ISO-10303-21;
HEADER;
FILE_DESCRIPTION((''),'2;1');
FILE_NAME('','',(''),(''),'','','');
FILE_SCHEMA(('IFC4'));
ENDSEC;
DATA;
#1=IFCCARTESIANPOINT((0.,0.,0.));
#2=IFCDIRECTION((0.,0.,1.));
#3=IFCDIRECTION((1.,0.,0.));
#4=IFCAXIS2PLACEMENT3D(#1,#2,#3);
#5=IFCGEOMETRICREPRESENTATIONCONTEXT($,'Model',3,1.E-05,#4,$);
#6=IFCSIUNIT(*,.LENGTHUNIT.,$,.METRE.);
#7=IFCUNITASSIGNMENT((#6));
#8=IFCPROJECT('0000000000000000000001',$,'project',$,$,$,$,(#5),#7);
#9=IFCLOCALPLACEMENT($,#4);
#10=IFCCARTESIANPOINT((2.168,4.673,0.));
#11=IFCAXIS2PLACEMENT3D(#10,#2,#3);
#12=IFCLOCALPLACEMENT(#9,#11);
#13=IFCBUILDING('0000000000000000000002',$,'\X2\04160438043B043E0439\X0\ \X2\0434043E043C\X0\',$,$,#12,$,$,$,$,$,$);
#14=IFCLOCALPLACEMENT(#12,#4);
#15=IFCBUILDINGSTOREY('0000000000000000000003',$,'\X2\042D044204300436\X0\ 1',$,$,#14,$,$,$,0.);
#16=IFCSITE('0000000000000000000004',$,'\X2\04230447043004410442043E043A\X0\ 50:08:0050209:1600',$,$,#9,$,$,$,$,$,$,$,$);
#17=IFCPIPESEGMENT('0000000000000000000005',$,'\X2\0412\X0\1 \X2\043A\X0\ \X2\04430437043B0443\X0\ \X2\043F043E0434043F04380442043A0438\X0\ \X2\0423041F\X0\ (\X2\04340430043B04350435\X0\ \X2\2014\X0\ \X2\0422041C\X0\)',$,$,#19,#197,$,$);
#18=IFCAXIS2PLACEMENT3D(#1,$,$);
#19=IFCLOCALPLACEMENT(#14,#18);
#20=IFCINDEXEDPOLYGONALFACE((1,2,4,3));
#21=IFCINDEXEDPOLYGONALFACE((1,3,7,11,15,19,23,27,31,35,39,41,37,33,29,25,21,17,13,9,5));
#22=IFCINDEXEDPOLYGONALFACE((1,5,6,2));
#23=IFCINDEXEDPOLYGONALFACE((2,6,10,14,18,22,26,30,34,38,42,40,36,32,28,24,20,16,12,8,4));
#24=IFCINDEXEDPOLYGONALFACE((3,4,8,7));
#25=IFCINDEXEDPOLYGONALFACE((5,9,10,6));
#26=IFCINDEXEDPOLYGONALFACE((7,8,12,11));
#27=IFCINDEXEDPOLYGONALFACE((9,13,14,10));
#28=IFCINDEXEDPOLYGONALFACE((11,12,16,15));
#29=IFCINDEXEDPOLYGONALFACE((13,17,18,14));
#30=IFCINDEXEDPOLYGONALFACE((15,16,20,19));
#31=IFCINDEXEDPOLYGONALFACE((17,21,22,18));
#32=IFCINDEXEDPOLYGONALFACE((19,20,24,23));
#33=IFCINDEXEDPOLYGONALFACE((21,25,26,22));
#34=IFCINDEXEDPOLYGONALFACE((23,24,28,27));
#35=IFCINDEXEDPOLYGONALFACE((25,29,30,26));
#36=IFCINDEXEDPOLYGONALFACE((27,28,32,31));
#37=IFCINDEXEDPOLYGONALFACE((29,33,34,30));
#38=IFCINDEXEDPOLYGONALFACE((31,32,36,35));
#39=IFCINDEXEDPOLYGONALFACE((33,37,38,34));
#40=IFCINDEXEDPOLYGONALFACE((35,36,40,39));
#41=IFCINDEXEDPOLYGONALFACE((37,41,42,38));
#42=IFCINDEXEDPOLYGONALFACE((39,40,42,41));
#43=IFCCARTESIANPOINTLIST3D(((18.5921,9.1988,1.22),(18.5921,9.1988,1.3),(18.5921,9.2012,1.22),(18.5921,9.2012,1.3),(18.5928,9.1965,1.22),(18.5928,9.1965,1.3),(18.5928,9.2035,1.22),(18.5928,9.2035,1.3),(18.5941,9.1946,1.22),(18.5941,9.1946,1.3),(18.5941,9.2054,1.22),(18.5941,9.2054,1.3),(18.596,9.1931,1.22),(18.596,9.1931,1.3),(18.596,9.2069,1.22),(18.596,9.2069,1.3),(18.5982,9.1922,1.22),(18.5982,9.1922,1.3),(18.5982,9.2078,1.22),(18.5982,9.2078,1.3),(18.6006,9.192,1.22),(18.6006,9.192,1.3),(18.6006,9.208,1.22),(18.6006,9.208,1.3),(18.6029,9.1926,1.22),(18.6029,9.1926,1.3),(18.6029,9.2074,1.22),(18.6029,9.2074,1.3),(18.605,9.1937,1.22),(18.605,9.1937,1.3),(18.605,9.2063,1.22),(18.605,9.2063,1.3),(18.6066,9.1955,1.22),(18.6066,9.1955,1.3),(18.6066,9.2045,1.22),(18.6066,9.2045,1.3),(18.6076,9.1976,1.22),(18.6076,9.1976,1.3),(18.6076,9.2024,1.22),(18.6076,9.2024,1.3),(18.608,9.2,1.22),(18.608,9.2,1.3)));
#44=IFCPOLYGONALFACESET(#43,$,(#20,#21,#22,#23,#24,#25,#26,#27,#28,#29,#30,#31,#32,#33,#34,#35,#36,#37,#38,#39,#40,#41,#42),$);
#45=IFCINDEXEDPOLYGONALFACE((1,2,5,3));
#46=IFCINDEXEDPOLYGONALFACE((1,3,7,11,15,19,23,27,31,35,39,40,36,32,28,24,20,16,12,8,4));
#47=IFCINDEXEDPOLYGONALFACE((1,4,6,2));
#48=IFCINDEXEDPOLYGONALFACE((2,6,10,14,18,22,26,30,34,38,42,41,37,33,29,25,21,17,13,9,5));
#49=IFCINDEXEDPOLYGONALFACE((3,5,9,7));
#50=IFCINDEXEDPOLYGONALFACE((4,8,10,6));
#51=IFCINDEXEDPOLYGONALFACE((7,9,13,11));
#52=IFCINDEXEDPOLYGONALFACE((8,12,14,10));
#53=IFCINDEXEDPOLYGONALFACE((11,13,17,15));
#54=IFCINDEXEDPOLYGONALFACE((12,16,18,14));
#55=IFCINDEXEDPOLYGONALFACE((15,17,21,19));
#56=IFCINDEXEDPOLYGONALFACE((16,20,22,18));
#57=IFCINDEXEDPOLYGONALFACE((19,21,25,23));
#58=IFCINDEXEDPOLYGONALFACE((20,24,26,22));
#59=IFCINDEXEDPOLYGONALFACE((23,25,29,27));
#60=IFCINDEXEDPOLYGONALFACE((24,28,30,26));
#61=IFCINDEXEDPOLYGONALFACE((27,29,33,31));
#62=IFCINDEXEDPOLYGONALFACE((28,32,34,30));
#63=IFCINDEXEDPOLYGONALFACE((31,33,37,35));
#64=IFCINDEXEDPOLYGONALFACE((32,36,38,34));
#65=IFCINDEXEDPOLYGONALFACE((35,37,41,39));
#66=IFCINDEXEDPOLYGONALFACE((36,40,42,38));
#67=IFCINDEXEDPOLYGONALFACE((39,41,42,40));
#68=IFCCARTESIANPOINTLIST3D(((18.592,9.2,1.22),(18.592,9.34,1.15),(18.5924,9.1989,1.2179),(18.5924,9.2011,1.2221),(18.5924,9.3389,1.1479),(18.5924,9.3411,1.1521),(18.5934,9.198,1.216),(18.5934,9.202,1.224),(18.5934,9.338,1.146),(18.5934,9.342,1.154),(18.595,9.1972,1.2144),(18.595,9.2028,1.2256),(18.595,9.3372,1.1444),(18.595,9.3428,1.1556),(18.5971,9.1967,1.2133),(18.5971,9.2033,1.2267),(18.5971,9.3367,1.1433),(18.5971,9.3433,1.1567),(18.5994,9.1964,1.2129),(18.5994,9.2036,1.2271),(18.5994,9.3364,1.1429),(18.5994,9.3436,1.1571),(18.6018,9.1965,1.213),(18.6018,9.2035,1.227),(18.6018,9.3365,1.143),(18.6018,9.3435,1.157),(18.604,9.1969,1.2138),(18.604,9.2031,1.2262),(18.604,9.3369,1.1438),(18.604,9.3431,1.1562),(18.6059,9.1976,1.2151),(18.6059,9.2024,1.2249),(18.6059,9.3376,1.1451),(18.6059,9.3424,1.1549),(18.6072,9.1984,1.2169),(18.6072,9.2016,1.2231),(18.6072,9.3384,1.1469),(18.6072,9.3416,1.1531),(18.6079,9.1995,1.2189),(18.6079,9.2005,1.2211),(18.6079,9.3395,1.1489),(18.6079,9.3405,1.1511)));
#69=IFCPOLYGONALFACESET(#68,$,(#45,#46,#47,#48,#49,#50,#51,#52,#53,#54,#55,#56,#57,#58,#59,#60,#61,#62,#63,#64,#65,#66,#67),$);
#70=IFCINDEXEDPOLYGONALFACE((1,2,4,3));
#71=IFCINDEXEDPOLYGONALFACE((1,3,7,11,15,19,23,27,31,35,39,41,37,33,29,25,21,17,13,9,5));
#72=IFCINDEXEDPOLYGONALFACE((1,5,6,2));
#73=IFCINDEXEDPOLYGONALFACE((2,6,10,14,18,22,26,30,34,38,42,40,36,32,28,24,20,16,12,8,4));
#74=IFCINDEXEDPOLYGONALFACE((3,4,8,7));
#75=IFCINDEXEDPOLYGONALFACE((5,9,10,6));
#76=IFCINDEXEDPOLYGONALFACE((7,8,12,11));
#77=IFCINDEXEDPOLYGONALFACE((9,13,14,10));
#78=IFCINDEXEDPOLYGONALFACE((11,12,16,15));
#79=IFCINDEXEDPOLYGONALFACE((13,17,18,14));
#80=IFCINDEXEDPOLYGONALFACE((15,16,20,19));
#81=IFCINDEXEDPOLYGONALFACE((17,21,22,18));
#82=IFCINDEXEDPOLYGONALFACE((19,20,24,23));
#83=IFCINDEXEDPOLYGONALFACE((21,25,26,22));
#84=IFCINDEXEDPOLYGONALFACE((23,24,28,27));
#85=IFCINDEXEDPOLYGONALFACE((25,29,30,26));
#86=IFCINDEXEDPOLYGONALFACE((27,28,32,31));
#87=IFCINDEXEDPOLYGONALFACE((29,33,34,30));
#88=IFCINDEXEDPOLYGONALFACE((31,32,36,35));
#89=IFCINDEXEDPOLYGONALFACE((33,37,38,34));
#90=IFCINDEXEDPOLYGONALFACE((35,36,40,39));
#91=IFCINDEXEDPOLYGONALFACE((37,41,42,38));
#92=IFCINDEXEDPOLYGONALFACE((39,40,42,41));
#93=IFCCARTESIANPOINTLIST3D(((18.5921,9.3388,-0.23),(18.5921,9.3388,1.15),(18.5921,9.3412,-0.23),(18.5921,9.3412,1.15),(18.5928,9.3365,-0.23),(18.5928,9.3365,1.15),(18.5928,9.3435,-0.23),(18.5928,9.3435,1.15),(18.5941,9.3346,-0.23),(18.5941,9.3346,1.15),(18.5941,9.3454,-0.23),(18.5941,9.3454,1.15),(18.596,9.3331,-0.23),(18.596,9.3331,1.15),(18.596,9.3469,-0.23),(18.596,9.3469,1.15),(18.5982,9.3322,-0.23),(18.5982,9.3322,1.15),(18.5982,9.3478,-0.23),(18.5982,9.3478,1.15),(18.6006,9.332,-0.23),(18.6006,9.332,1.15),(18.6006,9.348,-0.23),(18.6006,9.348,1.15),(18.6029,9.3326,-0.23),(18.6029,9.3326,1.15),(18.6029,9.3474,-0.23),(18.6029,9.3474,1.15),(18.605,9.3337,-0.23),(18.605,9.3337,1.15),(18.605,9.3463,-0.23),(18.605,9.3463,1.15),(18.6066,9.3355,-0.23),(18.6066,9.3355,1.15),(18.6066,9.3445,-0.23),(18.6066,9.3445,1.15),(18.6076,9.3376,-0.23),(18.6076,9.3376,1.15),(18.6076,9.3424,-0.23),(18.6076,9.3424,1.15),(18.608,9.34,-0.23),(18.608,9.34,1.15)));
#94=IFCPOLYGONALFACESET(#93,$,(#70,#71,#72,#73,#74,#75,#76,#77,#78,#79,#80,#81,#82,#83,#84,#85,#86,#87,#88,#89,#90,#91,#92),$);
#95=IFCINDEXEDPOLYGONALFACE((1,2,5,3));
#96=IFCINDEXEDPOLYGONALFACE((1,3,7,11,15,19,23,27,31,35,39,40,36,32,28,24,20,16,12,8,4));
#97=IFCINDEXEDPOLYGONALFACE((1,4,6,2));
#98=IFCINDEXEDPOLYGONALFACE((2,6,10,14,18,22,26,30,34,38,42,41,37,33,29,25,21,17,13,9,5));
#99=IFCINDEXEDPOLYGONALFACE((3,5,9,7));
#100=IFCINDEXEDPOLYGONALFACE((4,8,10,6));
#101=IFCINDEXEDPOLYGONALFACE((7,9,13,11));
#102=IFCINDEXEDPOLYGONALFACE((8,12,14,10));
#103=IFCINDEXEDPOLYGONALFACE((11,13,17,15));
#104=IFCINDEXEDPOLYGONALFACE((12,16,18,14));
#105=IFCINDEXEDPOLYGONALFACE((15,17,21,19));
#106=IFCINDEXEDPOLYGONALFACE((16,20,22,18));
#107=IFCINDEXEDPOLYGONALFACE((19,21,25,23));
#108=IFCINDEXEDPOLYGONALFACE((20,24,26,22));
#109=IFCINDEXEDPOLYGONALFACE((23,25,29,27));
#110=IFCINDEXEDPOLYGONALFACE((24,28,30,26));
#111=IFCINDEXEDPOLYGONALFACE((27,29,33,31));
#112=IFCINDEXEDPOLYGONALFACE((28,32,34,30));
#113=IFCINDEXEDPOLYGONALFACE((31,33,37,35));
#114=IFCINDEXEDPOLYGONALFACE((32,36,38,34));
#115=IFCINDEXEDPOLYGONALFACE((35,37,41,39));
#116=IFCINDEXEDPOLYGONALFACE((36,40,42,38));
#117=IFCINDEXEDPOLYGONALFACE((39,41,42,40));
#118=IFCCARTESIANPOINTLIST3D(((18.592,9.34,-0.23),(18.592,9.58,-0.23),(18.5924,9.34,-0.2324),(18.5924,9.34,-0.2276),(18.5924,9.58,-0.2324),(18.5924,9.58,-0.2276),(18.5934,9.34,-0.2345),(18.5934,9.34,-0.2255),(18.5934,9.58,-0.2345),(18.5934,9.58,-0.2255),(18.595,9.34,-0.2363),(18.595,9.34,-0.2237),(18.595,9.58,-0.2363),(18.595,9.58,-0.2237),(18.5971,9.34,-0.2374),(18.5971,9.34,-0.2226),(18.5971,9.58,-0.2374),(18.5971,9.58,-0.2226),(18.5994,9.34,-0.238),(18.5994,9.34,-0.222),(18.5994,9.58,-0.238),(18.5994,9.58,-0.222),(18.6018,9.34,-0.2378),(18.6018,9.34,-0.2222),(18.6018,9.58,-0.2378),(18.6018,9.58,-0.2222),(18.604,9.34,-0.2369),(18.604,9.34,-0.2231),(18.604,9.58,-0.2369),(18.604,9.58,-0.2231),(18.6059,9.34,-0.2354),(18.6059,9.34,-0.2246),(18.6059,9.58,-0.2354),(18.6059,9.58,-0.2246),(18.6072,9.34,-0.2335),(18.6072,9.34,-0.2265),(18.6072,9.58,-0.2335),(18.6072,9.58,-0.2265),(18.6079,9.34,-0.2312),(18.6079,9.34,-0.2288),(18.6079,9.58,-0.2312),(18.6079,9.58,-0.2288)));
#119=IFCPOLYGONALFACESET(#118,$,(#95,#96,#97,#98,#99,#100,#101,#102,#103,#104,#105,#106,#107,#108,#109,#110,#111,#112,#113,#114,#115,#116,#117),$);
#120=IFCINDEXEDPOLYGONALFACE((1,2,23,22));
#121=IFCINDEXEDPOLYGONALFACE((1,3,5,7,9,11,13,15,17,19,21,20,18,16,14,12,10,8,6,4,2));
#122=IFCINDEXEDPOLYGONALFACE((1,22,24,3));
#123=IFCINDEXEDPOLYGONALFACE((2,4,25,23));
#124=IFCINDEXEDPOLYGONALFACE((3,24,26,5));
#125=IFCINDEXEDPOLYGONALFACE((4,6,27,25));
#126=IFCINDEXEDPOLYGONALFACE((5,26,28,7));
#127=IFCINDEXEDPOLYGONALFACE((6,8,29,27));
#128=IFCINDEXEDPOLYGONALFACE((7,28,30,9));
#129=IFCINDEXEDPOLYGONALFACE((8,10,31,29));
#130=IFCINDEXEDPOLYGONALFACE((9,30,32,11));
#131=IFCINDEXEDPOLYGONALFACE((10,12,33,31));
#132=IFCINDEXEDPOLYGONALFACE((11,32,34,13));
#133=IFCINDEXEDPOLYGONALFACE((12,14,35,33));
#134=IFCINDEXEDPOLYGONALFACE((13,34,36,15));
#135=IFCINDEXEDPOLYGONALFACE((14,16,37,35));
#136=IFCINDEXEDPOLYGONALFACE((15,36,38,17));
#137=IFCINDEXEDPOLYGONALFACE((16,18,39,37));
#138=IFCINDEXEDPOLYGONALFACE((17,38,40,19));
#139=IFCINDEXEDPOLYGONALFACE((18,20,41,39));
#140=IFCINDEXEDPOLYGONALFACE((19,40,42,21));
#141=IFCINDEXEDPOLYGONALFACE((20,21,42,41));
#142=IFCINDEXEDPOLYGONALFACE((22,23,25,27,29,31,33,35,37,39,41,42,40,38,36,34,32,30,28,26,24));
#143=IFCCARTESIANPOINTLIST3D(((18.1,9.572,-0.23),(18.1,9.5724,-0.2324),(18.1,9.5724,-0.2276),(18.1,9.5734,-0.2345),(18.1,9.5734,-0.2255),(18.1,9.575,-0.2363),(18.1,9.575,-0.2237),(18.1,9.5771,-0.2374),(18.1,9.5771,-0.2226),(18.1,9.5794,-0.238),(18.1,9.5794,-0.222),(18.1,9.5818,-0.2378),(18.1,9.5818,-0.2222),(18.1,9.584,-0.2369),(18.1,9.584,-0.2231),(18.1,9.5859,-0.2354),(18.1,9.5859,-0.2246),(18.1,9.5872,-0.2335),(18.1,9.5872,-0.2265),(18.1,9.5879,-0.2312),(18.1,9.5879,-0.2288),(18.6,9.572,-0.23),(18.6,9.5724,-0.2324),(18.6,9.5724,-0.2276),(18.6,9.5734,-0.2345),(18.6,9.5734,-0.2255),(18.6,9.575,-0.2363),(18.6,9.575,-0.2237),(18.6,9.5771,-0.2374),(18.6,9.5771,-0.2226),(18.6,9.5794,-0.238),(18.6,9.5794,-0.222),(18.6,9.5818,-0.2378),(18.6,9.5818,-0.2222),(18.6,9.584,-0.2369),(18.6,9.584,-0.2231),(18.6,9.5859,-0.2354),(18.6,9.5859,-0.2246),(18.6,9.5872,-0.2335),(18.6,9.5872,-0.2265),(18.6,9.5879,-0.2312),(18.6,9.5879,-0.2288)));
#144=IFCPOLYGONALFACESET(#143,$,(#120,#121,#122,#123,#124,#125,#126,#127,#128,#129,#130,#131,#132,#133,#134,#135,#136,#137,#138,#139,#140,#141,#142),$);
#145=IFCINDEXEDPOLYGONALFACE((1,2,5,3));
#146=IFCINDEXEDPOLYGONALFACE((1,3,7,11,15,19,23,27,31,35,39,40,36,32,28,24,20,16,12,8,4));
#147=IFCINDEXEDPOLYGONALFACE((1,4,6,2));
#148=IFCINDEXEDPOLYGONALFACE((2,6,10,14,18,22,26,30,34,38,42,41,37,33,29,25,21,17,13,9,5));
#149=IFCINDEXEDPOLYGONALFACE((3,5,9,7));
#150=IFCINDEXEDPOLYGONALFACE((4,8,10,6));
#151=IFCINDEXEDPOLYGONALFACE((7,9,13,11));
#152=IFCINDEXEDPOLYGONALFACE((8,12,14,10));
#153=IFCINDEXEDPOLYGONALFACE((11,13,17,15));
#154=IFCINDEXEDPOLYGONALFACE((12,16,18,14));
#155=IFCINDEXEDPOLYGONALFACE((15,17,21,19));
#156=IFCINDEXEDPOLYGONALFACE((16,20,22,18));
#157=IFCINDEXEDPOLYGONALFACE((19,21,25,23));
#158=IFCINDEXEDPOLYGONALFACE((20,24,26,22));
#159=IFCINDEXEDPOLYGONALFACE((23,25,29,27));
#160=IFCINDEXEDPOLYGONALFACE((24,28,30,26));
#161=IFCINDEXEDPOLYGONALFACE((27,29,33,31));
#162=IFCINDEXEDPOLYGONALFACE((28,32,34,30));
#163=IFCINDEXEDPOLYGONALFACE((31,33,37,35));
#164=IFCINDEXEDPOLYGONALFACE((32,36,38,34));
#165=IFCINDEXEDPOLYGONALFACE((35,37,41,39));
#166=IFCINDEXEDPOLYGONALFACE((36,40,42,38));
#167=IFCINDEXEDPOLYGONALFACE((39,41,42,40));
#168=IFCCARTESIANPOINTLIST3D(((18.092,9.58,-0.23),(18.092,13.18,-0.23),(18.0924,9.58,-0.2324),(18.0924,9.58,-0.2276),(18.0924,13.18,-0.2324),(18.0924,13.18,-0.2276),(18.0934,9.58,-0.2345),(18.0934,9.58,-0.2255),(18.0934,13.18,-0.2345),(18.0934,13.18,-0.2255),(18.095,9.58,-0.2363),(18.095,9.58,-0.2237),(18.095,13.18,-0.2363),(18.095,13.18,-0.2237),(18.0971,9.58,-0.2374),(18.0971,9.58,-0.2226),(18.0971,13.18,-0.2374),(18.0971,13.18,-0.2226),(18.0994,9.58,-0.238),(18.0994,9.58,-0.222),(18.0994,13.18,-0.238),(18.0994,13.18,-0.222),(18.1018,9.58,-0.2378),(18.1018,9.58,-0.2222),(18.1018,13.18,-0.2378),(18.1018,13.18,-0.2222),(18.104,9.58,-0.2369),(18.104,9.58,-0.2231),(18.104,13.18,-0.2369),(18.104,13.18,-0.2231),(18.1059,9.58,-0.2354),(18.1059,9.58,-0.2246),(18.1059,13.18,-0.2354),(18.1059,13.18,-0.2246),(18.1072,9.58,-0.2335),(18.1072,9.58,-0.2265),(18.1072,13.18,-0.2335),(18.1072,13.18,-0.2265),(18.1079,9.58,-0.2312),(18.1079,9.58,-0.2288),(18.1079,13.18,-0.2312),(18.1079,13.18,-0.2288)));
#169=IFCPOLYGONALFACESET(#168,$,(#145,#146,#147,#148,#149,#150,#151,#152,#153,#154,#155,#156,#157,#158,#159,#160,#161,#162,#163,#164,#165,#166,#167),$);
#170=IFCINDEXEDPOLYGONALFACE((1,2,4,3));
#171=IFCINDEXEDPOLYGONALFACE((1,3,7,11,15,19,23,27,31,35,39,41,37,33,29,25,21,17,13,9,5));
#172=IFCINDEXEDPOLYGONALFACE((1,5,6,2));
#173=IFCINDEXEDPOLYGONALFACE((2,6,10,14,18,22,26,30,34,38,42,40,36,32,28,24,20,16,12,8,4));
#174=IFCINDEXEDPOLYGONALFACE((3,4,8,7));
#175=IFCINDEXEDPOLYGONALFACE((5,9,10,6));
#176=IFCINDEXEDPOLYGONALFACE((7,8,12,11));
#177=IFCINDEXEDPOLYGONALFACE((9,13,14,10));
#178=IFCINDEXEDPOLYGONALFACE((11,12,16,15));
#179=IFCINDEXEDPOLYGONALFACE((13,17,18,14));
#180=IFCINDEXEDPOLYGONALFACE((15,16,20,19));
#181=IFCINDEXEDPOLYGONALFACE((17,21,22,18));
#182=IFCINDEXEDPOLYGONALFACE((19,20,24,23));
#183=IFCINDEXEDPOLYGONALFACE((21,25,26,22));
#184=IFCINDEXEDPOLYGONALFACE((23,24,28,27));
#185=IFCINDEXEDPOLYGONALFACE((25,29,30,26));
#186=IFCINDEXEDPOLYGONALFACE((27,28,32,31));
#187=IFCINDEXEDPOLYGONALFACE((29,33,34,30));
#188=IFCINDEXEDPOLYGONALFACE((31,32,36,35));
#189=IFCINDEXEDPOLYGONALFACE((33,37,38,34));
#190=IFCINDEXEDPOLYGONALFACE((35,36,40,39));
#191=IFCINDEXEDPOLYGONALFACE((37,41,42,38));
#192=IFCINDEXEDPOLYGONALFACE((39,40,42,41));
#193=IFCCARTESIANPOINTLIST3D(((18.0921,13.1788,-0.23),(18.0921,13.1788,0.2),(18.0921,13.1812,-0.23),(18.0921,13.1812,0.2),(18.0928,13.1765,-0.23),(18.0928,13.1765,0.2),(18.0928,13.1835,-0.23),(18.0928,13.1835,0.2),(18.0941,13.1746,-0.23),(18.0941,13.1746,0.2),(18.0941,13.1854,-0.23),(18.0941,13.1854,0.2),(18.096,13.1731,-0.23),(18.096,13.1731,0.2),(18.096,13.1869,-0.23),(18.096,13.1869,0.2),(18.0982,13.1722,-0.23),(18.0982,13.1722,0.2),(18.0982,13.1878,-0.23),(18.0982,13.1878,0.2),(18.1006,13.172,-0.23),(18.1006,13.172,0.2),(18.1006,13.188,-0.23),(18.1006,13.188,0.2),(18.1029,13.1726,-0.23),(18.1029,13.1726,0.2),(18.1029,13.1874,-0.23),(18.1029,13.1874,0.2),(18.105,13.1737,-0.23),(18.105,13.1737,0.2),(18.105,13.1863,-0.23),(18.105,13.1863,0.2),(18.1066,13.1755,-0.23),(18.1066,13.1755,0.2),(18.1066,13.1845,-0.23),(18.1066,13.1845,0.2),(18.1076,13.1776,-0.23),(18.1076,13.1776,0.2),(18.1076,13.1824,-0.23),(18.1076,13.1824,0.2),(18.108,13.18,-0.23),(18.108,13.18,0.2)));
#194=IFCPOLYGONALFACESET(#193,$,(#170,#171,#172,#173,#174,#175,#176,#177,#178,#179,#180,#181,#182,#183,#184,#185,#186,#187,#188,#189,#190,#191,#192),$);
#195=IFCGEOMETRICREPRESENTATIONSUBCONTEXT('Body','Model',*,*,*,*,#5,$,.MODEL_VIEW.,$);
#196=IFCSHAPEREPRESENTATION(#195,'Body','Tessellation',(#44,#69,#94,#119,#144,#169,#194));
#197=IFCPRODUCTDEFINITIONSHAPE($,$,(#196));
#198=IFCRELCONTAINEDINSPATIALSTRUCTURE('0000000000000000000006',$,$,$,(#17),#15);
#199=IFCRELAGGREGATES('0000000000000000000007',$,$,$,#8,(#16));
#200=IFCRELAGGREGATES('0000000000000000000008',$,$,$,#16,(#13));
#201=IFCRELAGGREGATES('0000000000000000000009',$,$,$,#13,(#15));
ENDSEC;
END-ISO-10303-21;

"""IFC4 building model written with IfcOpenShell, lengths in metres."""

from ifc_helpers import new_model, si_unit, frame, origin_with_axes, origin_2d, place, context, subcontext, project, spatial, circle, extrude, element, save


model = new_model("IFC4")

# Units and contexts
model_context = context("Model", 3, precision=1e-05, world=origin_with_axes())
body_context = subcontext(model_context, "Body", "Model", "MODEL_VIEW")
ifc_project = project(units=[si_unit("LENGTHUNIT", "METRE")], contexts=[model_context])

# Site, building, storey
site_placement = place(None, origin_with_axes())
site = spatial("IfcSite", under=ifc_project, at=site_placement, Name="Участок 50:08:0050209:1600")
building_placement = place(site_placement, frame((2.168, 4.673, 0.0), z_axis=(0.0, 0.0, 1.0), x_axis=(1.0, 0.0, 0.0)))
building = spatial("IfcBuilding", under=site, at=building_placement, Name="Жилой дом")
storey_placement = place(building_placement, origin_with_axes())
storey = spatial("IfcBuildingStorey", under=building, at=storey_placement, Name="Этаж 1", Elevation=0.0)

# Pipe segment
pipe_segment_1_placement = place(storey_placement, origin_with_axes())
element("IfcPipeSegment", 1, at=pipe_segment_1_placement, inside=storey, Name="В1 к узлу подпитки УП (далее — ТМ)", context=body_context, shape_type="SweptSolid", body=[
    extrude(circle(Radius=0.008, at=origin_2d()), frame((18.6, 9.2, 1.3), z_axis=(0.0, 0.0, -1.0), x_axis=(1.0, 0.0, 0.0)), (0.0, 0.0, 1.0), 0.08),
    extrude(circle(Radius=0.008, at=origin_2d()), frame((18.6, 9.2, 1.22), z_axis=(0.0, 0.894427, -0.447214), x_axis=(-1.0, 0.0, 0.0)), (0.0, 0.0, 1.0), 0.1565),
    extrude(circle(Radius=0.008, at=origin_2d()), frame((18.6, 9.34, 1.15), z_axis=(0.0, 0.0, -1.0), x_axis=(1.0, 0.0, 0.0)), (0.0, 0.0, 1.0), 1.38),
    extrude(circle(Radius=0.008, at=origin_2d()), frame((18.6, 9.34, -0.23), z_axis=(0.0, 1.0, 0.0), x_axis=(-1.0, 0.0, 0.0)), (0.0, 0.0, 1.0), 0.24),
    extrude(circle(Radius=0.008, at=origin_2d()), frame((18.6, 9.58, -0.23), z_axis=(-1.0, 0.0, 0.0), x_axis=(0.0, -1.0, 0.0)), (0.0, 0.0, 1.0), 0.5),
    extrude(circle(Radius=0.008, at=origin_2d()), frame((18.1, 9.58, -0.23), z_axis=(0.0, 1.0, 0.0), x_axis=(-1.0, 0.0, 0.0)), (0.0, 0.0, 1.0), 3.6),
    extrude(circle(Radius=0.008, at=origin_2d()), frame((18.1, 13.18, -0.23), z_axis=(0.0, 0.0, 1.0), x_axis=(1.0, 0.0, 0.0)), (0.0, 0.0, 1.0), 0.43),
])

save(model, "model.ifc")
